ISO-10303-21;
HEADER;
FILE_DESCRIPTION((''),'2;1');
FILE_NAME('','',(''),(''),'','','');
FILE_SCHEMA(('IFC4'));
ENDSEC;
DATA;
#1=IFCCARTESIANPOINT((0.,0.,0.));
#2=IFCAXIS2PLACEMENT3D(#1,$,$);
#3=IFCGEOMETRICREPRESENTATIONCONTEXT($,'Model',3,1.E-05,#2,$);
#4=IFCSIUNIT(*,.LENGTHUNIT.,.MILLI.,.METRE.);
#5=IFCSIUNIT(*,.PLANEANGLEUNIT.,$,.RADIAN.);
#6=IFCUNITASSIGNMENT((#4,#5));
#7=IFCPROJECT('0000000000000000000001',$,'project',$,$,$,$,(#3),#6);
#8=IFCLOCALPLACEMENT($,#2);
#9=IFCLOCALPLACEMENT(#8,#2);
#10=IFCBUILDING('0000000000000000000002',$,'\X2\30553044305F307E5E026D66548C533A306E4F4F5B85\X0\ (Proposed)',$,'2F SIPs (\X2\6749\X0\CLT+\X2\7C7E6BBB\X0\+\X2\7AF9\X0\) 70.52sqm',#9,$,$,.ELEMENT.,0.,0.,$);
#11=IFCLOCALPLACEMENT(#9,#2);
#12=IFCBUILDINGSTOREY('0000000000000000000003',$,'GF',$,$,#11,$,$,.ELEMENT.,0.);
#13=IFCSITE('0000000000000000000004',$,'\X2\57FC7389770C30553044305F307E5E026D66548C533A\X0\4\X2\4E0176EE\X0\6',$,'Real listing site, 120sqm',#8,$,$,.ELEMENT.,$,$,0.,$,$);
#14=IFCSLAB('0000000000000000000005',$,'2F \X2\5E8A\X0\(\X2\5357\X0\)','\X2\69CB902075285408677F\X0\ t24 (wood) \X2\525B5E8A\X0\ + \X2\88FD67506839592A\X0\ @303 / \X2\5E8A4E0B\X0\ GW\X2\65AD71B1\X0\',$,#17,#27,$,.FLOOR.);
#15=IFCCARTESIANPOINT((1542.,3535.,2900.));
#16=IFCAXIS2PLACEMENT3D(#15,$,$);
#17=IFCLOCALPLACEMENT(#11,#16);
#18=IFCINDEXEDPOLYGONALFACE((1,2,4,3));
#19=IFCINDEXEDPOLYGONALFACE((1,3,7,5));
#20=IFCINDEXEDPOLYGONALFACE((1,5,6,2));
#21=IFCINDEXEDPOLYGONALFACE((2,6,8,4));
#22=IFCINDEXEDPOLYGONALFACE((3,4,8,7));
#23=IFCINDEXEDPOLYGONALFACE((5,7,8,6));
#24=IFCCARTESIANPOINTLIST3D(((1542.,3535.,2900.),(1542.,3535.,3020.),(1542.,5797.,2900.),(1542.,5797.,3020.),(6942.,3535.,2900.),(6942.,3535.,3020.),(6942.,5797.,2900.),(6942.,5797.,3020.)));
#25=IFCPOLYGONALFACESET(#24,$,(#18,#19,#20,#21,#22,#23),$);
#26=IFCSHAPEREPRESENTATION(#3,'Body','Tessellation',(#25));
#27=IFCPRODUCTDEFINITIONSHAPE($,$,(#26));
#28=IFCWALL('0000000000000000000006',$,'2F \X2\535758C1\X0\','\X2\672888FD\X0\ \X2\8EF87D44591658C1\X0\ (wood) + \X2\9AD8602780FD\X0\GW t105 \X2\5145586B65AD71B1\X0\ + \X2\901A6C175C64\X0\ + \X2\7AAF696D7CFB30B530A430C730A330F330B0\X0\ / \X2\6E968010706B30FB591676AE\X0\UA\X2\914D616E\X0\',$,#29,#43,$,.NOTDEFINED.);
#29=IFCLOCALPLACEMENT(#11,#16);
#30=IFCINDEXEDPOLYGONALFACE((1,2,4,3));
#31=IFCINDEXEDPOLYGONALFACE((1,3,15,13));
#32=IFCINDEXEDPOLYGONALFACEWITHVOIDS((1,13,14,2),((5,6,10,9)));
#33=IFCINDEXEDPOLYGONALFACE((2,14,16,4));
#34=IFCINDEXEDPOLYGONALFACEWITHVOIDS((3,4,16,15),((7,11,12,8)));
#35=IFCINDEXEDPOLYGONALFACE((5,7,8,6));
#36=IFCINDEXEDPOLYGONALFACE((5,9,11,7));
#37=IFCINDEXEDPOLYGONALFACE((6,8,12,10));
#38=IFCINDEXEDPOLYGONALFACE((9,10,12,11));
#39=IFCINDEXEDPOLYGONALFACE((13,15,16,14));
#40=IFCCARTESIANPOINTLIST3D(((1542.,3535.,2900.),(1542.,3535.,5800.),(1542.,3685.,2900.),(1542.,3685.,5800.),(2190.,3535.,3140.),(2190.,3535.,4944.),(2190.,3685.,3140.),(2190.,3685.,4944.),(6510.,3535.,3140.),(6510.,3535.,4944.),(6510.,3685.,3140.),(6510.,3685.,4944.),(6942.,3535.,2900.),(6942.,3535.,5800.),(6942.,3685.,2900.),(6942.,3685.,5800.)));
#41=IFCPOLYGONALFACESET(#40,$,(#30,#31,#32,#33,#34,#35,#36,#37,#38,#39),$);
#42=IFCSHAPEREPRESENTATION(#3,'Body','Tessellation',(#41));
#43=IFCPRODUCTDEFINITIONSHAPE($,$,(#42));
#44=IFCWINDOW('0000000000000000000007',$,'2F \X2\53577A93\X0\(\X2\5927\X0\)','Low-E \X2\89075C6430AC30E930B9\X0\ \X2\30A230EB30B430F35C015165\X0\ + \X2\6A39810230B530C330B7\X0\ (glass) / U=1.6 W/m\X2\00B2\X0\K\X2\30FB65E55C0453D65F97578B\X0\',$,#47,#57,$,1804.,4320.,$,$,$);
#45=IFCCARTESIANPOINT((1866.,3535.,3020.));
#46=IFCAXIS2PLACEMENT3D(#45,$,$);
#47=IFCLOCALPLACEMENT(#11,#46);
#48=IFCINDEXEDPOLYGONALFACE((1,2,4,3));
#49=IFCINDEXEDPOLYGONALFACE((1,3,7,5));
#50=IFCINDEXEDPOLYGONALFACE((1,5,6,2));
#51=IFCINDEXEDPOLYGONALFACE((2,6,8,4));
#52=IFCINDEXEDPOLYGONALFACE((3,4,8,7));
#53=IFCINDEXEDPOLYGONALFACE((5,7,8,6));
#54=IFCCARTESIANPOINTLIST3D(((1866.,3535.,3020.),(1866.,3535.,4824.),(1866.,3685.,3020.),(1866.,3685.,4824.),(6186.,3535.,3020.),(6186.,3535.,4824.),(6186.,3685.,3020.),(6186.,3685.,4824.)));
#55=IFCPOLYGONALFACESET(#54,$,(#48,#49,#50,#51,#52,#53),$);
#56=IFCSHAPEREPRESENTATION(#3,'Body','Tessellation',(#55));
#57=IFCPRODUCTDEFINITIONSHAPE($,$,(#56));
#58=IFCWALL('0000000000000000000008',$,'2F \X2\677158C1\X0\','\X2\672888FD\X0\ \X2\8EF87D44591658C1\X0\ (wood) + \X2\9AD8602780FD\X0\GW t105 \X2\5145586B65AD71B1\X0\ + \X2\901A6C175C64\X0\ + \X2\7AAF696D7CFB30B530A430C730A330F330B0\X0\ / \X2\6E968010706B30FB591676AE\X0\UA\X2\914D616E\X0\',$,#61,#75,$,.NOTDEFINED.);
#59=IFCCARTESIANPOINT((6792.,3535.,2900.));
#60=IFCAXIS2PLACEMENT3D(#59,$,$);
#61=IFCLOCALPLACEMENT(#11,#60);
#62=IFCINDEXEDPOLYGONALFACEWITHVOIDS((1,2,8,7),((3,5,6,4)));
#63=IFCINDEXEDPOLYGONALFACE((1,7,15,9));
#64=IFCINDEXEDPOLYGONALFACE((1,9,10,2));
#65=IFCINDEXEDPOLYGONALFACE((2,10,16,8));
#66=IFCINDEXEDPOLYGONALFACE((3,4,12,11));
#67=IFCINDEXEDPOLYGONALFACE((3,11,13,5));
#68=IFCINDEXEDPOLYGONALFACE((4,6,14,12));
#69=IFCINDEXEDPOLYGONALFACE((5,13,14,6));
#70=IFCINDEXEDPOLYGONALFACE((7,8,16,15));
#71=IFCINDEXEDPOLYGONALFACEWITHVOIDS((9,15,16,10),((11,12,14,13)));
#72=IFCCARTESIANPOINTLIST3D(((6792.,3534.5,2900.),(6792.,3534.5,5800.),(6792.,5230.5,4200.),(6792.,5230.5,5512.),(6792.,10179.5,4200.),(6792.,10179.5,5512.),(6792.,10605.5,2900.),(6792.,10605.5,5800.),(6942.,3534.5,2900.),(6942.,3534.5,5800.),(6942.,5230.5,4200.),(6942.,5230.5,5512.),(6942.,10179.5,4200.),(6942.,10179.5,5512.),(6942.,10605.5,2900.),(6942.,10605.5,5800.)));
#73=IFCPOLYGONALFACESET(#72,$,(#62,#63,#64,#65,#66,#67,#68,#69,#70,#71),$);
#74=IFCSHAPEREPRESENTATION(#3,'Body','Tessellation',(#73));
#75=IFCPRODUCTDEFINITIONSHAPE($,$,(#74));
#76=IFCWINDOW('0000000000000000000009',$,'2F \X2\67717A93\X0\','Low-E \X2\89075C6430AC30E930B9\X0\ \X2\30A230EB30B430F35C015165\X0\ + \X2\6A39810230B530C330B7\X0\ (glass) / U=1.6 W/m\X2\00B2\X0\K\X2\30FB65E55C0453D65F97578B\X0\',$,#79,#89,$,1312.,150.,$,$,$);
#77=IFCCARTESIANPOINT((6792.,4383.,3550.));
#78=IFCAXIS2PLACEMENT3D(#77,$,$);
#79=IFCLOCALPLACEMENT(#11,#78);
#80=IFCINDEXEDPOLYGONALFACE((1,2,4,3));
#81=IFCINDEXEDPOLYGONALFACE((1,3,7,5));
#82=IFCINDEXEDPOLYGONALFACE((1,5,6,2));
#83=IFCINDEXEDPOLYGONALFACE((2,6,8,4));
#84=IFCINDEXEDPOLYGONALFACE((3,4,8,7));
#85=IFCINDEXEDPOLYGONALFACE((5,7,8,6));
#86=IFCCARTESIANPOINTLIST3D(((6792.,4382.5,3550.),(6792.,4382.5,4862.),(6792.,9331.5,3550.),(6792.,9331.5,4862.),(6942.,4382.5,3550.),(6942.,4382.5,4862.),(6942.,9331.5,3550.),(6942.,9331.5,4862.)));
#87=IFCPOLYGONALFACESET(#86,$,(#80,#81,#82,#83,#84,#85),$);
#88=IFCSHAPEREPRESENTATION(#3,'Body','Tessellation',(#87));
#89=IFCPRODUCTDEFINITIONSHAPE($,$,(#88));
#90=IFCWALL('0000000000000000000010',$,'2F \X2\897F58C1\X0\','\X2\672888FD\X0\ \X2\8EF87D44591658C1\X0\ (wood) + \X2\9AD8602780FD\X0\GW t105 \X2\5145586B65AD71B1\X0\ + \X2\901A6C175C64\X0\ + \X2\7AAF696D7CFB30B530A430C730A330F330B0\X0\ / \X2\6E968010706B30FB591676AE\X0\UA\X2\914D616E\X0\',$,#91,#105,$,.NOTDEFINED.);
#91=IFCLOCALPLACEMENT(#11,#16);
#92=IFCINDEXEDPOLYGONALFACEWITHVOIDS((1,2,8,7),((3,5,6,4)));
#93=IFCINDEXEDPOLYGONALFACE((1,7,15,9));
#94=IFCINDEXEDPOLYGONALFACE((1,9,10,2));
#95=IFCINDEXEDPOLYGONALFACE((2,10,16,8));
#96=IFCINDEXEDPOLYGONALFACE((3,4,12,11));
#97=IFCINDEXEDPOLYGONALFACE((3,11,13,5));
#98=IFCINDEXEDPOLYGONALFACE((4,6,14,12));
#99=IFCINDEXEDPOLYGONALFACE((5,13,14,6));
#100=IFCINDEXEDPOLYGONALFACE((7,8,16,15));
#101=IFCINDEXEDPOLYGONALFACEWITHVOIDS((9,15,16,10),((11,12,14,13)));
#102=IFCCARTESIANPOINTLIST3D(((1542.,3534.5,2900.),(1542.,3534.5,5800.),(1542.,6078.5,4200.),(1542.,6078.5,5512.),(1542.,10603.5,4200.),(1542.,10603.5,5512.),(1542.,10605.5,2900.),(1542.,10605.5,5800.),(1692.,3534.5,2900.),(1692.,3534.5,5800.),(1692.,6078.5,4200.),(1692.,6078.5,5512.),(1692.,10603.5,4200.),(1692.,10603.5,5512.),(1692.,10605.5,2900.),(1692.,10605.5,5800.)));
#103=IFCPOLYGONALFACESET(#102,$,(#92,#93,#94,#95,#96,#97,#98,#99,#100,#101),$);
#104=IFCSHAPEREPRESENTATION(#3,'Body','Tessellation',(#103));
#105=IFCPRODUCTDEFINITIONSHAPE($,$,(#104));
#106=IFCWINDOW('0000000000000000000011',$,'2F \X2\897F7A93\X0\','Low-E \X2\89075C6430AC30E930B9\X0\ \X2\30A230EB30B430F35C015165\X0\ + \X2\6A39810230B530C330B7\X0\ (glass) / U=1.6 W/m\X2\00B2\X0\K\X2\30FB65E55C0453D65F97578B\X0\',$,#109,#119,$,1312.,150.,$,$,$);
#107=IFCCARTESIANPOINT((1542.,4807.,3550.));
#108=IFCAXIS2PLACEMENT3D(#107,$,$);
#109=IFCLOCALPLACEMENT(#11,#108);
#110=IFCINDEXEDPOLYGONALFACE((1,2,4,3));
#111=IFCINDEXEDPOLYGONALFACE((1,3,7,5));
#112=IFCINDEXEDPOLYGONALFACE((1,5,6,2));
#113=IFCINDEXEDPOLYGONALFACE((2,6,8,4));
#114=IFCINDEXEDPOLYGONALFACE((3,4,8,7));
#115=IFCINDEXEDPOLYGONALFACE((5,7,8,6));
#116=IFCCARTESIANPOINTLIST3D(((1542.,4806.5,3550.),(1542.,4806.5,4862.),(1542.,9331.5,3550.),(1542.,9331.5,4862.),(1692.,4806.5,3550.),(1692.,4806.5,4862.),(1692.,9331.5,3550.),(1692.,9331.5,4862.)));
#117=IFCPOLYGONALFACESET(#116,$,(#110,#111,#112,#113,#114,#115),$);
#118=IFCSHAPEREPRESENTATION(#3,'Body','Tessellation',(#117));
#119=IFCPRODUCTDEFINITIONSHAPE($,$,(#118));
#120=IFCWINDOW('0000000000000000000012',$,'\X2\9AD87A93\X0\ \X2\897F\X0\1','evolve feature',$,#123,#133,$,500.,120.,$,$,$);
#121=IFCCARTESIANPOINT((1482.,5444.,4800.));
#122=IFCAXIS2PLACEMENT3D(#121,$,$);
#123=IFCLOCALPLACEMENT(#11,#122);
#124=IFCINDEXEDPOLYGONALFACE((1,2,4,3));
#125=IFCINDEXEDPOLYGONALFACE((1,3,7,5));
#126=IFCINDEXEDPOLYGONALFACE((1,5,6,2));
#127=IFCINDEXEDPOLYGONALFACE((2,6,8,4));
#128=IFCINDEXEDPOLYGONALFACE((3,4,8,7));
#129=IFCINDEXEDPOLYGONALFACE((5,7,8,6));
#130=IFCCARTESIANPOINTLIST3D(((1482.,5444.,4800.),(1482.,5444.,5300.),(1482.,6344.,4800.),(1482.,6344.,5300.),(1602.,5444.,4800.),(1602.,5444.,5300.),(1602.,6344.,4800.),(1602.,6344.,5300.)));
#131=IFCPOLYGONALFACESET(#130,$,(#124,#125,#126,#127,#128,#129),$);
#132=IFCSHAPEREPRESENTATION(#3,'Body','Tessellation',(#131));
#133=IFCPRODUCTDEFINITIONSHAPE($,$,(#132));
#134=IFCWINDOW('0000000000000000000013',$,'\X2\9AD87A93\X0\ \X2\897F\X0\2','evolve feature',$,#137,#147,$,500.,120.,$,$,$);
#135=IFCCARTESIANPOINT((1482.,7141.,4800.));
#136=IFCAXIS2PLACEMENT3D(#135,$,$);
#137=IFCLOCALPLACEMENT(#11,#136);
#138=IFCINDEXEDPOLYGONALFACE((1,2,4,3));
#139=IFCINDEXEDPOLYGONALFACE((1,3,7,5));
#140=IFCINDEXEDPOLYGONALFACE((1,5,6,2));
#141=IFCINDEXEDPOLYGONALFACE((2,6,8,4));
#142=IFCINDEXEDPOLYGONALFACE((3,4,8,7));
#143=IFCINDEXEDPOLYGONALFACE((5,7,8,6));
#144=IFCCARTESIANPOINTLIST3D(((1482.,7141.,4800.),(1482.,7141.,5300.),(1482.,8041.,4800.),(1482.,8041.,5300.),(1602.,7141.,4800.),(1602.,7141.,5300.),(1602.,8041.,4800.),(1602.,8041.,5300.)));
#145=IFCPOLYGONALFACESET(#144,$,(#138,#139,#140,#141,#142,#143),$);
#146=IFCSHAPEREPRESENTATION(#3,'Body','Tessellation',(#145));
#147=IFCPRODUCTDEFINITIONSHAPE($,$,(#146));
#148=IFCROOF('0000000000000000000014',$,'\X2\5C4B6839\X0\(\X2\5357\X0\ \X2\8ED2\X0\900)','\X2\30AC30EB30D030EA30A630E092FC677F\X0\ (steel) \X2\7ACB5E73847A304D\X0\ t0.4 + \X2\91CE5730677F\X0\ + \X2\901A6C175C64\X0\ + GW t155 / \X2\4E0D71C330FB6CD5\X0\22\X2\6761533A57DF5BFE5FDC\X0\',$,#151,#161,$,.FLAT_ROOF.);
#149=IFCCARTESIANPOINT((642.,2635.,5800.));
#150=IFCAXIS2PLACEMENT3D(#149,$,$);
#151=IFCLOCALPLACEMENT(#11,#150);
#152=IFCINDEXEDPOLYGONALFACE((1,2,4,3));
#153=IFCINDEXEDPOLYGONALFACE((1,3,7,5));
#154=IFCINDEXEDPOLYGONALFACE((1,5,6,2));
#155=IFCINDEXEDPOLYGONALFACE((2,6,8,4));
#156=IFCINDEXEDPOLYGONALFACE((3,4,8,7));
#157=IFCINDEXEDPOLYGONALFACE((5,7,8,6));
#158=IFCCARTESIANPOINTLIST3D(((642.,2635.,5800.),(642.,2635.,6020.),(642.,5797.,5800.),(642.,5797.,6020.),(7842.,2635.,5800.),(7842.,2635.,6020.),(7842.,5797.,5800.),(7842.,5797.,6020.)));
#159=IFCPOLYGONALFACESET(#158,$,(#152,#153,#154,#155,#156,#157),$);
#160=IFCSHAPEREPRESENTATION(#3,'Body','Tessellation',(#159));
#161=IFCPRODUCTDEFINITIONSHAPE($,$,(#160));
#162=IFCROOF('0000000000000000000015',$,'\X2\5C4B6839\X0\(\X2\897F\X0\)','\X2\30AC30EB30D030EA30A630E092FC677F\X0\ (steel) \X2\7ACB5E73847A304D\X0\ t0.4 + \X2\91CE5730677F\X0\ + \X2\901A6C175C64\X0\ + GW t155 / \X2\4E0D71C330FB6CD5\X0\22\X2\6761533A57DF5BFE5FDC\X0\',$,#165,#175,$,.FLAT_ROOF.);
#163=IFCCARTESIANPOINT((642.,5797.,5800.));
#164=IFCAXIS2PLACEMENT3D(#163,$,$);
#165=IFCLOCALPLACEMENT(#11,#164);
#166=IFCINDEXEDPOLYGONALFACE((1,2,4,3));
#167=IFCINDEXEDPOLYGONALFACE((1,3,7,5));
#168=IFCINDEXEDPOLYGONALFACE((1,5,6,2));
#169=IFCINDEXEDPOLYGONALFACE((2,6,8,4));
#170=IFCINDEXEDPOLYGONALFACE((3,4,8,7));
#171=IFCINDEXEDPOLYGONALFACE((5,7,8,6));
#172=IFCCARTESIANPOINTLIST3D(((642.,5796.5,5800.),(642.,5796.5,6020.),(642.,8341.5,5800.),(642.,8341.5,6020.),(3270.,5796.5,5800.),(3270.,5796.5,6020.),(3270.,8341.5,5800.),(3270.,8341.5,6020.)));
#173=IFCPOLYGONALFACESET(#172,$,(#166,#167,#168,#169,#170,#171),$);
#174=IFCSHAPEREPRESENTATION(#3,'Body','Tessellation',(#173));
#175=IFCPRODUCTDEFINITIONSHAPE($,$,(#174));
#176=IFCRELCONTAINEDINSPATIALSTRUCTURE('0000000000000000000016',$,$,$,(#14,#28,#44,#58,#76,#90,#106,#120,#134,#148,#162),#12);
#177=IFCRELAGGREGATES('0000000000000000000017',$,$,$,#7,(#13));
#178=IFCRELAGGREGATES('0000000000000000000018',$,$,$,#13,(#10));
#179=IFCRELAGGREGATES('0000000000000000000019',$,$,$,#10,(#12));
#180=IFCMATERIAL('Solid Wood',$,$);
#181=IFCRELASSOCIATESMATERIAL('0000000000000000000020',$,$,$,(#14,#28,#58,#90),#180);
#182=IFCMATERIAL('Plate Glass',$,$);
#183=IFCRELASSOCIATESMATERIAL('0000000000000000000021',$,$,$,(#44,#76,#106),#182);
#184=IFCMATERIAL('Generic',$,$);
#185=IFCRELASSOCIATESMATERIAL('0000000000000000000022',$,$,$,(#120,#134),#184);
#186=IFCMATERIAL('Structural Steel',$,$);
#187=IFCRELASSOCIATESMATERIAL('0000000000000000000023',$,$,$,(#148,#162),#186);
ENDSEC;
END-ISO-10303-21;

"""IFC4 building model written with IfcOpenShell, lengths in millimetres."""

from ifc_helpers import new_model, si_unit, frame, frame_2d, origin, place, context, project, spatial, rectangle, extrude, material, element, fill, save


model = new_model("IFC4")

# Units and contexts
model_context = context("Model", 3, precision=1e-05, world=origin())
ifc_project = project(units=[si_unit("LENGTHUNIT", "METRE", prefix="MILLI"), si_unit("PLANEANGLEUNIT", "RADIAN")], contexts=[model_context])

# Site, building, storey
site_placement = place(None, origin())
site = spatial("IfcSite", under=ifc_project, at=site_placement, Name="埼玉県さいたま市浦和区4丁目6", ObjectType="Real listing site, 120sqm", CompositionType="ELEMENT", RefElevation=0.0)
building_placement = place(site_placement, origin())
building = spatial("IfcBuilding", under=site, at=building_placement, Name="さいたま市浦和区の住宅 (Proposed)", ObjectType="2F SIPs (杉CLT+籾殻+竹) 70.52sqm", CompositionType="ELEMENT", ElevationOfRefHeight=0.0, ElevationOfTerrain=0.0)
storey_placement = place(building_placement, origin())
storey = spatial("IfcBuildingStorey", under=building, at=storey_placement, Name="GF", CompositionType="ELEMENT", Elevation=0.0)

# Slab
ifc_material_1 = material(Name="Solid Wood")
slab_placement = place(storey_placement, frame((1542.0, 3535.0, 2900.0)))
element("IfcSlab", 1, at=slab_placement, inside=storey, material=ifc_material_1, Name="2F 床(南)", Description="構造用合板 t24 (wood) 剛床 + 製材根太 @303 / 床下 GW断熱", PredefinedType="FLOOR", context=model_context, shape_type="SweptSolid", body=[
    extrude(rectangle(XDim=5400.0, YDim=2262.0, at=frame_2d((2700.0, 1131.0))), frame((1542.0, 3535.0, 2900.0)), (0.0, 0.0, 1.0), 120.0),
])

# Walls, openings, windows
wall_1_placement = place(storey_placement, frame((1542.0, 3535.0, 2900.0)))
wall_1 = element("IfcWall", 2, at=wall_1_placement, inside=storey, material=ifc_material_1, Name="2F 南壁", Description="木製 軸組外壁 (wood) + 高性能GW t105 充填断熱 + 通気層 + 窯業系サイディング / 準耐火・外皮UA配慮", PredefinedType="NOTDEFINED", context=model_context, shape_type="SweptSolid", body=[
    extrude(rectangle(XDim=5400.0, YDim=150.0, at=frame_2d((2700.0, 75.0))), frame((1542.0, 3535.0, 2900.0)), (0.0, 0.0, 1.0), 2900.0),
])
opening_1_placement = place(storey_placement, frame((1866.0, 3535.0, 3020.0)))
opening_1 = element("IfcOpeningElement", 3, at=opening_1_placement, cuts=wall_1, PredefinedType="NOTDEFINED", context=model_context, shape_type="SweptSolid", body=[
    extrude(rectangle(XDim=4320.0, YDim=150.0, at=frame_2d((2160.0, 75.0))), frame((1866.0, 3535.0, 3020.0)), (0.0, 0.0, 1.0), 1804.0),
])
ifc_material_2 = material(Name="Plate Glass")
window_1_placement = place(storey_placement, frame((1866.0, 3535.0, 3020.0)))
window_1 = element("IfcWindow", 4, at=window_1_placement, inside=storey, material=ifc_material_2, Name="2F 南窓(大)", Description="Low-E 複層ガラス アルゴン封入 + 樹脂サッシ (glass) / U=1.6 W/m²K・日射取得型", OverallHeight=1804.0, OverallWidth=4320.0, context=model_context, shape_type="SweptSolid", body=[
    extrude(rectangle(XDim=4320.0, YDim=150.0, at=frame_2d((2160.0, 75.0))), frame((1866.0, 3535.0, 3020.0)), (0.0, 0.0, 1.0), 1804.0),
])
fill(opening_1, window_1)
wall_2_placement = place(storey_placement, frame((6792.0, 3535.0, 2900.0)))
wall_2 = element("IfcWall", 5, at=wall_2_placement, inside=storey, material=ifc_material_1, Name="2F 東壁", Description="木製 軸組外壁 (wood) + 高性能GW t105 充填断熱 + 通気層 + 窯業系サイディング / 準耐火・外皮UA配慮", PredefinedType="NOTDEFINED", context=model_context, shape_type="SweptSolid", body=[
    extrude(rectangle(XDim=150.0, YDim=7071.0, at=frame_2d((75.0, 3535.0))), frame((6792.0, 3535.0, 2900.0)), (0.0, 0.0, 1.0), 2900.0),
])
opening_2_placement = place(storey_placement, frame((6792.0, 4383.0, 3550.0)))
opening_2 = element("IfcOpeningElement", 6, at=opening_2_placement, cuts=wall_2, PredefinedType="NOTDEFINED", context=model_context, shape_type="SweptSolid", body=[
    extrude(rectangle(XDim=150.0, YDim=4949.0, at=frame_2d((75.0, 2474.0))), frame((6792.0, 4383.0, 3550.0)), (0.0, 0.0, 1.0), 1312.0),
])
window_2_placement = place(storey_placement, frame((6792.0, 4383.0, 3550.0)))
window_2 = element("IfcWindow", 7, at=window_2_placement, inside=storey, material=ifc_material_2, Name="2F 東窓", Description="Low-E 複層ガラス アルゴン封入 + 樹脂サッシ (glass) / U=1.6 W/m²K・日射取得型", OverallHeight=1312.0, OverallWidth=150.0, context=model_context, shape_type="SweptSolid", body=[
    extrude(rectangle(XDim=150.0, YDim=4949.0, at=frame_2d((75.0, 2474.0))), frame((6792.0, 4383.0, 3550.0)), (0.0, 0.0, 1.0), 1312.0),
])
fill(opening_2, window_2)

# Wall, openings, windows
wall_3_placement = place(storey_placement, frame((1542.0, 3535.0, 2900.0)))
wall_3 = element("IfcWall", 8, at=wall_3_placement, inside=storey, material=ifc_material_1, Name="2F 西壁", Description="木製 軸組外壁 (wood) + 高性能GW t105 充填断熱 + 通気層 + 窯業系サイディング / 準耐火・外皮UA配慮", PredefinedType="NOTDEFINED", context=model_context, shape_type="SweptSolid", body=[
    extrude(rectangle(XDim=150.0, YDim=7071.0, at=frame_2d((75.0, 3535.0))), frame((1542.0, 3535.0, 2900.0)), (0.0, 0.0, 1.0), 2900.0),
])
opening_3_placement = place(storey_placement, frame((1542.0, 4807.0, 3550.0)))
opening_3 = element("IfcOpeningElement", 9, at=opening_3_placement, cuts=wall_3, PredefinedType="NOTDEFINED", context=model_context, shape_type="SweptSolid", body=[
    extrude(rectangle(XDim=150.0, YDim=4525.0, at=frame_2d((75.0, 2262.0))), frame((1542.0, 4807.0, 3550.0)), (0.0, 0.0, 1.0), 1312.0),
])
opening_4_placement = place(storey_placement, frame((1482.0, 5444.0, 4800.0)))
opening_4 = element("IfcOpeningElement", 10, at=opening_4_placement, cuts=wall_3, PredefinedType="NOTDEFINED", context=model_context, shape_type="SweptSolid", body=[
    extrude(rectangle(XDim=120.0, YDim=900.0, at=frame_2d((60.0, 450.0))), frame((1482.0, 5444.0, 4800.0)), (0.0, 0.0, 1.0), 500.0),
])
opening_5_placement = place(storey_placement, frame((1482.0, 7141.0, 4800.0)))
opening_5 = element("IfcOpeningElement", 11, at=opening_5_placement, cuts=wall_3, PredefinedType="NOTDEFINED", context=model_context, shape_type="SweptSolid", body=[
    extrude(rectangle(XDim=120.0, YDim=900.0, at=frame_2d((60.0, 450.0))), frame((1482.0, 7141.0, 4800.0)), (0.0, 0.0, 1.0), 500.0),
])
window_3_placement = place(storey_placement, frame((1542.0, 4807.0, 3550.0)))
window_3 = element("IfcWindow", 12, at=window_3_placement, inside=storey, material=ifc_material_2, Name="2F 西窓", Description="Low-E 複層ガラス アルゴン封入 + 樹脂サッシ (glass) / U=1.6 W/m²K・日射取得型", OverallHeight=1312.0, OverallWidth=150.0, context=model_context, shape_type="SweptSolid", body=[
    extrude(rectangle(XDim=150.0, YDim=4525.0, at=frame_2d((75.0, 2262.0))), frame((1542.0, 4807.0, 3550.0)), (0.0, 0.0, 1.0), 1312.0),
])
fill(opening_3, window_3)
ifc_material_3 = material(Name="Generic")
window_4_placement = place(storey_placement, frame((1482.0, 5444.0, 4800.0)))
window_4 = element("IfcWindow", 13, at=window_4_placement, inside=storey, material=ifc_material_3, Name="高窓 西1", Description="evolve feature", OverallHeight=500.0, OverallWidth=120.0, context=model_context, shape_type="SweptSolid", body=[
    extrude(rectangle(XDim=120.0, YDim=900.0, at=frame_2d((60.0, 450.0))), frame((1482.0, 5444.0, 4800.0)), (0.0, 0.0, 1.0), 500.0),
])
fill(opening_4, window_4)
window_5_placement = place(storey_placement, frame((1482.0, 7141.0, 4800.0)))
window_5 = element("IfcWindow", 14, at=window_5_placement, inside=storey, material=ifc_material_3, Name="高窓 西2", Description="evolve feature", OverallHeight=500.0, OverallWidth=120.0, context=model_context, shape_type="SweptSolid", body=[
    extrude(rectangle(XDim=120.0, YDim=900.0, at=frame_2d((60.0, 450.0))), frame((1482.0, 7141.0, 4800.0)), (0.0, 0.0, 1.0), 500.0),
])
fill(opening_5, window_5)

# Roofs
ifc_material_4 = material(Name="Structural Steel")
roof_1_placement = place(storey_placement, frame((642.0, 2635.0, 5800.0)))
element("IfcRoof", 15, at=roof_1_placement, inside=storey, material=ifc_material_4, Name="屋根(南 軒900)", Description="ガルバリウム鋼板 (steel) 立平葺き t0.4 + 野地板 + 通気層 + GW t155 / 不燃・法22条区域対応", PredefinedType="FLAT_ROOF", context=model_context, shape_type="SweptSolid", body=[
    extrude(rectangle(XDim=7200.0, YDim=3162.0, at=frame_2d((3600.0, 1581.0))), frame((642.0, 2635.0, 5800.0)), (0.0, 0.0, 1.0), 220.0),
])
roof_2_placement = place(storey_placement, frame((642.0, 5797.0, 5800.0)))
element("IfcRoof", 16, at=roof_2_placement, inside=storey, material=ifc_material_4, Name="屋根(西)", Description="ガルバリウム鋼板 (steel) 立平葺き t0.4 + 野地板 + 通気層 + GW t155 / 不燃・法22条区域対応", PredefinedType="FLAT_ROOF", context=model_context, shape_type="SweptSolid", body=[
    extrude(rectangle(XDim=2628.0, YDim=2545.0, at=frame_2d((1314.0, 1272.0))), frame((642.0, 5797.0, 5800.0)), (0.0, 0.0, 1.0), 220.0),
])

save(model, "model.ifc")
